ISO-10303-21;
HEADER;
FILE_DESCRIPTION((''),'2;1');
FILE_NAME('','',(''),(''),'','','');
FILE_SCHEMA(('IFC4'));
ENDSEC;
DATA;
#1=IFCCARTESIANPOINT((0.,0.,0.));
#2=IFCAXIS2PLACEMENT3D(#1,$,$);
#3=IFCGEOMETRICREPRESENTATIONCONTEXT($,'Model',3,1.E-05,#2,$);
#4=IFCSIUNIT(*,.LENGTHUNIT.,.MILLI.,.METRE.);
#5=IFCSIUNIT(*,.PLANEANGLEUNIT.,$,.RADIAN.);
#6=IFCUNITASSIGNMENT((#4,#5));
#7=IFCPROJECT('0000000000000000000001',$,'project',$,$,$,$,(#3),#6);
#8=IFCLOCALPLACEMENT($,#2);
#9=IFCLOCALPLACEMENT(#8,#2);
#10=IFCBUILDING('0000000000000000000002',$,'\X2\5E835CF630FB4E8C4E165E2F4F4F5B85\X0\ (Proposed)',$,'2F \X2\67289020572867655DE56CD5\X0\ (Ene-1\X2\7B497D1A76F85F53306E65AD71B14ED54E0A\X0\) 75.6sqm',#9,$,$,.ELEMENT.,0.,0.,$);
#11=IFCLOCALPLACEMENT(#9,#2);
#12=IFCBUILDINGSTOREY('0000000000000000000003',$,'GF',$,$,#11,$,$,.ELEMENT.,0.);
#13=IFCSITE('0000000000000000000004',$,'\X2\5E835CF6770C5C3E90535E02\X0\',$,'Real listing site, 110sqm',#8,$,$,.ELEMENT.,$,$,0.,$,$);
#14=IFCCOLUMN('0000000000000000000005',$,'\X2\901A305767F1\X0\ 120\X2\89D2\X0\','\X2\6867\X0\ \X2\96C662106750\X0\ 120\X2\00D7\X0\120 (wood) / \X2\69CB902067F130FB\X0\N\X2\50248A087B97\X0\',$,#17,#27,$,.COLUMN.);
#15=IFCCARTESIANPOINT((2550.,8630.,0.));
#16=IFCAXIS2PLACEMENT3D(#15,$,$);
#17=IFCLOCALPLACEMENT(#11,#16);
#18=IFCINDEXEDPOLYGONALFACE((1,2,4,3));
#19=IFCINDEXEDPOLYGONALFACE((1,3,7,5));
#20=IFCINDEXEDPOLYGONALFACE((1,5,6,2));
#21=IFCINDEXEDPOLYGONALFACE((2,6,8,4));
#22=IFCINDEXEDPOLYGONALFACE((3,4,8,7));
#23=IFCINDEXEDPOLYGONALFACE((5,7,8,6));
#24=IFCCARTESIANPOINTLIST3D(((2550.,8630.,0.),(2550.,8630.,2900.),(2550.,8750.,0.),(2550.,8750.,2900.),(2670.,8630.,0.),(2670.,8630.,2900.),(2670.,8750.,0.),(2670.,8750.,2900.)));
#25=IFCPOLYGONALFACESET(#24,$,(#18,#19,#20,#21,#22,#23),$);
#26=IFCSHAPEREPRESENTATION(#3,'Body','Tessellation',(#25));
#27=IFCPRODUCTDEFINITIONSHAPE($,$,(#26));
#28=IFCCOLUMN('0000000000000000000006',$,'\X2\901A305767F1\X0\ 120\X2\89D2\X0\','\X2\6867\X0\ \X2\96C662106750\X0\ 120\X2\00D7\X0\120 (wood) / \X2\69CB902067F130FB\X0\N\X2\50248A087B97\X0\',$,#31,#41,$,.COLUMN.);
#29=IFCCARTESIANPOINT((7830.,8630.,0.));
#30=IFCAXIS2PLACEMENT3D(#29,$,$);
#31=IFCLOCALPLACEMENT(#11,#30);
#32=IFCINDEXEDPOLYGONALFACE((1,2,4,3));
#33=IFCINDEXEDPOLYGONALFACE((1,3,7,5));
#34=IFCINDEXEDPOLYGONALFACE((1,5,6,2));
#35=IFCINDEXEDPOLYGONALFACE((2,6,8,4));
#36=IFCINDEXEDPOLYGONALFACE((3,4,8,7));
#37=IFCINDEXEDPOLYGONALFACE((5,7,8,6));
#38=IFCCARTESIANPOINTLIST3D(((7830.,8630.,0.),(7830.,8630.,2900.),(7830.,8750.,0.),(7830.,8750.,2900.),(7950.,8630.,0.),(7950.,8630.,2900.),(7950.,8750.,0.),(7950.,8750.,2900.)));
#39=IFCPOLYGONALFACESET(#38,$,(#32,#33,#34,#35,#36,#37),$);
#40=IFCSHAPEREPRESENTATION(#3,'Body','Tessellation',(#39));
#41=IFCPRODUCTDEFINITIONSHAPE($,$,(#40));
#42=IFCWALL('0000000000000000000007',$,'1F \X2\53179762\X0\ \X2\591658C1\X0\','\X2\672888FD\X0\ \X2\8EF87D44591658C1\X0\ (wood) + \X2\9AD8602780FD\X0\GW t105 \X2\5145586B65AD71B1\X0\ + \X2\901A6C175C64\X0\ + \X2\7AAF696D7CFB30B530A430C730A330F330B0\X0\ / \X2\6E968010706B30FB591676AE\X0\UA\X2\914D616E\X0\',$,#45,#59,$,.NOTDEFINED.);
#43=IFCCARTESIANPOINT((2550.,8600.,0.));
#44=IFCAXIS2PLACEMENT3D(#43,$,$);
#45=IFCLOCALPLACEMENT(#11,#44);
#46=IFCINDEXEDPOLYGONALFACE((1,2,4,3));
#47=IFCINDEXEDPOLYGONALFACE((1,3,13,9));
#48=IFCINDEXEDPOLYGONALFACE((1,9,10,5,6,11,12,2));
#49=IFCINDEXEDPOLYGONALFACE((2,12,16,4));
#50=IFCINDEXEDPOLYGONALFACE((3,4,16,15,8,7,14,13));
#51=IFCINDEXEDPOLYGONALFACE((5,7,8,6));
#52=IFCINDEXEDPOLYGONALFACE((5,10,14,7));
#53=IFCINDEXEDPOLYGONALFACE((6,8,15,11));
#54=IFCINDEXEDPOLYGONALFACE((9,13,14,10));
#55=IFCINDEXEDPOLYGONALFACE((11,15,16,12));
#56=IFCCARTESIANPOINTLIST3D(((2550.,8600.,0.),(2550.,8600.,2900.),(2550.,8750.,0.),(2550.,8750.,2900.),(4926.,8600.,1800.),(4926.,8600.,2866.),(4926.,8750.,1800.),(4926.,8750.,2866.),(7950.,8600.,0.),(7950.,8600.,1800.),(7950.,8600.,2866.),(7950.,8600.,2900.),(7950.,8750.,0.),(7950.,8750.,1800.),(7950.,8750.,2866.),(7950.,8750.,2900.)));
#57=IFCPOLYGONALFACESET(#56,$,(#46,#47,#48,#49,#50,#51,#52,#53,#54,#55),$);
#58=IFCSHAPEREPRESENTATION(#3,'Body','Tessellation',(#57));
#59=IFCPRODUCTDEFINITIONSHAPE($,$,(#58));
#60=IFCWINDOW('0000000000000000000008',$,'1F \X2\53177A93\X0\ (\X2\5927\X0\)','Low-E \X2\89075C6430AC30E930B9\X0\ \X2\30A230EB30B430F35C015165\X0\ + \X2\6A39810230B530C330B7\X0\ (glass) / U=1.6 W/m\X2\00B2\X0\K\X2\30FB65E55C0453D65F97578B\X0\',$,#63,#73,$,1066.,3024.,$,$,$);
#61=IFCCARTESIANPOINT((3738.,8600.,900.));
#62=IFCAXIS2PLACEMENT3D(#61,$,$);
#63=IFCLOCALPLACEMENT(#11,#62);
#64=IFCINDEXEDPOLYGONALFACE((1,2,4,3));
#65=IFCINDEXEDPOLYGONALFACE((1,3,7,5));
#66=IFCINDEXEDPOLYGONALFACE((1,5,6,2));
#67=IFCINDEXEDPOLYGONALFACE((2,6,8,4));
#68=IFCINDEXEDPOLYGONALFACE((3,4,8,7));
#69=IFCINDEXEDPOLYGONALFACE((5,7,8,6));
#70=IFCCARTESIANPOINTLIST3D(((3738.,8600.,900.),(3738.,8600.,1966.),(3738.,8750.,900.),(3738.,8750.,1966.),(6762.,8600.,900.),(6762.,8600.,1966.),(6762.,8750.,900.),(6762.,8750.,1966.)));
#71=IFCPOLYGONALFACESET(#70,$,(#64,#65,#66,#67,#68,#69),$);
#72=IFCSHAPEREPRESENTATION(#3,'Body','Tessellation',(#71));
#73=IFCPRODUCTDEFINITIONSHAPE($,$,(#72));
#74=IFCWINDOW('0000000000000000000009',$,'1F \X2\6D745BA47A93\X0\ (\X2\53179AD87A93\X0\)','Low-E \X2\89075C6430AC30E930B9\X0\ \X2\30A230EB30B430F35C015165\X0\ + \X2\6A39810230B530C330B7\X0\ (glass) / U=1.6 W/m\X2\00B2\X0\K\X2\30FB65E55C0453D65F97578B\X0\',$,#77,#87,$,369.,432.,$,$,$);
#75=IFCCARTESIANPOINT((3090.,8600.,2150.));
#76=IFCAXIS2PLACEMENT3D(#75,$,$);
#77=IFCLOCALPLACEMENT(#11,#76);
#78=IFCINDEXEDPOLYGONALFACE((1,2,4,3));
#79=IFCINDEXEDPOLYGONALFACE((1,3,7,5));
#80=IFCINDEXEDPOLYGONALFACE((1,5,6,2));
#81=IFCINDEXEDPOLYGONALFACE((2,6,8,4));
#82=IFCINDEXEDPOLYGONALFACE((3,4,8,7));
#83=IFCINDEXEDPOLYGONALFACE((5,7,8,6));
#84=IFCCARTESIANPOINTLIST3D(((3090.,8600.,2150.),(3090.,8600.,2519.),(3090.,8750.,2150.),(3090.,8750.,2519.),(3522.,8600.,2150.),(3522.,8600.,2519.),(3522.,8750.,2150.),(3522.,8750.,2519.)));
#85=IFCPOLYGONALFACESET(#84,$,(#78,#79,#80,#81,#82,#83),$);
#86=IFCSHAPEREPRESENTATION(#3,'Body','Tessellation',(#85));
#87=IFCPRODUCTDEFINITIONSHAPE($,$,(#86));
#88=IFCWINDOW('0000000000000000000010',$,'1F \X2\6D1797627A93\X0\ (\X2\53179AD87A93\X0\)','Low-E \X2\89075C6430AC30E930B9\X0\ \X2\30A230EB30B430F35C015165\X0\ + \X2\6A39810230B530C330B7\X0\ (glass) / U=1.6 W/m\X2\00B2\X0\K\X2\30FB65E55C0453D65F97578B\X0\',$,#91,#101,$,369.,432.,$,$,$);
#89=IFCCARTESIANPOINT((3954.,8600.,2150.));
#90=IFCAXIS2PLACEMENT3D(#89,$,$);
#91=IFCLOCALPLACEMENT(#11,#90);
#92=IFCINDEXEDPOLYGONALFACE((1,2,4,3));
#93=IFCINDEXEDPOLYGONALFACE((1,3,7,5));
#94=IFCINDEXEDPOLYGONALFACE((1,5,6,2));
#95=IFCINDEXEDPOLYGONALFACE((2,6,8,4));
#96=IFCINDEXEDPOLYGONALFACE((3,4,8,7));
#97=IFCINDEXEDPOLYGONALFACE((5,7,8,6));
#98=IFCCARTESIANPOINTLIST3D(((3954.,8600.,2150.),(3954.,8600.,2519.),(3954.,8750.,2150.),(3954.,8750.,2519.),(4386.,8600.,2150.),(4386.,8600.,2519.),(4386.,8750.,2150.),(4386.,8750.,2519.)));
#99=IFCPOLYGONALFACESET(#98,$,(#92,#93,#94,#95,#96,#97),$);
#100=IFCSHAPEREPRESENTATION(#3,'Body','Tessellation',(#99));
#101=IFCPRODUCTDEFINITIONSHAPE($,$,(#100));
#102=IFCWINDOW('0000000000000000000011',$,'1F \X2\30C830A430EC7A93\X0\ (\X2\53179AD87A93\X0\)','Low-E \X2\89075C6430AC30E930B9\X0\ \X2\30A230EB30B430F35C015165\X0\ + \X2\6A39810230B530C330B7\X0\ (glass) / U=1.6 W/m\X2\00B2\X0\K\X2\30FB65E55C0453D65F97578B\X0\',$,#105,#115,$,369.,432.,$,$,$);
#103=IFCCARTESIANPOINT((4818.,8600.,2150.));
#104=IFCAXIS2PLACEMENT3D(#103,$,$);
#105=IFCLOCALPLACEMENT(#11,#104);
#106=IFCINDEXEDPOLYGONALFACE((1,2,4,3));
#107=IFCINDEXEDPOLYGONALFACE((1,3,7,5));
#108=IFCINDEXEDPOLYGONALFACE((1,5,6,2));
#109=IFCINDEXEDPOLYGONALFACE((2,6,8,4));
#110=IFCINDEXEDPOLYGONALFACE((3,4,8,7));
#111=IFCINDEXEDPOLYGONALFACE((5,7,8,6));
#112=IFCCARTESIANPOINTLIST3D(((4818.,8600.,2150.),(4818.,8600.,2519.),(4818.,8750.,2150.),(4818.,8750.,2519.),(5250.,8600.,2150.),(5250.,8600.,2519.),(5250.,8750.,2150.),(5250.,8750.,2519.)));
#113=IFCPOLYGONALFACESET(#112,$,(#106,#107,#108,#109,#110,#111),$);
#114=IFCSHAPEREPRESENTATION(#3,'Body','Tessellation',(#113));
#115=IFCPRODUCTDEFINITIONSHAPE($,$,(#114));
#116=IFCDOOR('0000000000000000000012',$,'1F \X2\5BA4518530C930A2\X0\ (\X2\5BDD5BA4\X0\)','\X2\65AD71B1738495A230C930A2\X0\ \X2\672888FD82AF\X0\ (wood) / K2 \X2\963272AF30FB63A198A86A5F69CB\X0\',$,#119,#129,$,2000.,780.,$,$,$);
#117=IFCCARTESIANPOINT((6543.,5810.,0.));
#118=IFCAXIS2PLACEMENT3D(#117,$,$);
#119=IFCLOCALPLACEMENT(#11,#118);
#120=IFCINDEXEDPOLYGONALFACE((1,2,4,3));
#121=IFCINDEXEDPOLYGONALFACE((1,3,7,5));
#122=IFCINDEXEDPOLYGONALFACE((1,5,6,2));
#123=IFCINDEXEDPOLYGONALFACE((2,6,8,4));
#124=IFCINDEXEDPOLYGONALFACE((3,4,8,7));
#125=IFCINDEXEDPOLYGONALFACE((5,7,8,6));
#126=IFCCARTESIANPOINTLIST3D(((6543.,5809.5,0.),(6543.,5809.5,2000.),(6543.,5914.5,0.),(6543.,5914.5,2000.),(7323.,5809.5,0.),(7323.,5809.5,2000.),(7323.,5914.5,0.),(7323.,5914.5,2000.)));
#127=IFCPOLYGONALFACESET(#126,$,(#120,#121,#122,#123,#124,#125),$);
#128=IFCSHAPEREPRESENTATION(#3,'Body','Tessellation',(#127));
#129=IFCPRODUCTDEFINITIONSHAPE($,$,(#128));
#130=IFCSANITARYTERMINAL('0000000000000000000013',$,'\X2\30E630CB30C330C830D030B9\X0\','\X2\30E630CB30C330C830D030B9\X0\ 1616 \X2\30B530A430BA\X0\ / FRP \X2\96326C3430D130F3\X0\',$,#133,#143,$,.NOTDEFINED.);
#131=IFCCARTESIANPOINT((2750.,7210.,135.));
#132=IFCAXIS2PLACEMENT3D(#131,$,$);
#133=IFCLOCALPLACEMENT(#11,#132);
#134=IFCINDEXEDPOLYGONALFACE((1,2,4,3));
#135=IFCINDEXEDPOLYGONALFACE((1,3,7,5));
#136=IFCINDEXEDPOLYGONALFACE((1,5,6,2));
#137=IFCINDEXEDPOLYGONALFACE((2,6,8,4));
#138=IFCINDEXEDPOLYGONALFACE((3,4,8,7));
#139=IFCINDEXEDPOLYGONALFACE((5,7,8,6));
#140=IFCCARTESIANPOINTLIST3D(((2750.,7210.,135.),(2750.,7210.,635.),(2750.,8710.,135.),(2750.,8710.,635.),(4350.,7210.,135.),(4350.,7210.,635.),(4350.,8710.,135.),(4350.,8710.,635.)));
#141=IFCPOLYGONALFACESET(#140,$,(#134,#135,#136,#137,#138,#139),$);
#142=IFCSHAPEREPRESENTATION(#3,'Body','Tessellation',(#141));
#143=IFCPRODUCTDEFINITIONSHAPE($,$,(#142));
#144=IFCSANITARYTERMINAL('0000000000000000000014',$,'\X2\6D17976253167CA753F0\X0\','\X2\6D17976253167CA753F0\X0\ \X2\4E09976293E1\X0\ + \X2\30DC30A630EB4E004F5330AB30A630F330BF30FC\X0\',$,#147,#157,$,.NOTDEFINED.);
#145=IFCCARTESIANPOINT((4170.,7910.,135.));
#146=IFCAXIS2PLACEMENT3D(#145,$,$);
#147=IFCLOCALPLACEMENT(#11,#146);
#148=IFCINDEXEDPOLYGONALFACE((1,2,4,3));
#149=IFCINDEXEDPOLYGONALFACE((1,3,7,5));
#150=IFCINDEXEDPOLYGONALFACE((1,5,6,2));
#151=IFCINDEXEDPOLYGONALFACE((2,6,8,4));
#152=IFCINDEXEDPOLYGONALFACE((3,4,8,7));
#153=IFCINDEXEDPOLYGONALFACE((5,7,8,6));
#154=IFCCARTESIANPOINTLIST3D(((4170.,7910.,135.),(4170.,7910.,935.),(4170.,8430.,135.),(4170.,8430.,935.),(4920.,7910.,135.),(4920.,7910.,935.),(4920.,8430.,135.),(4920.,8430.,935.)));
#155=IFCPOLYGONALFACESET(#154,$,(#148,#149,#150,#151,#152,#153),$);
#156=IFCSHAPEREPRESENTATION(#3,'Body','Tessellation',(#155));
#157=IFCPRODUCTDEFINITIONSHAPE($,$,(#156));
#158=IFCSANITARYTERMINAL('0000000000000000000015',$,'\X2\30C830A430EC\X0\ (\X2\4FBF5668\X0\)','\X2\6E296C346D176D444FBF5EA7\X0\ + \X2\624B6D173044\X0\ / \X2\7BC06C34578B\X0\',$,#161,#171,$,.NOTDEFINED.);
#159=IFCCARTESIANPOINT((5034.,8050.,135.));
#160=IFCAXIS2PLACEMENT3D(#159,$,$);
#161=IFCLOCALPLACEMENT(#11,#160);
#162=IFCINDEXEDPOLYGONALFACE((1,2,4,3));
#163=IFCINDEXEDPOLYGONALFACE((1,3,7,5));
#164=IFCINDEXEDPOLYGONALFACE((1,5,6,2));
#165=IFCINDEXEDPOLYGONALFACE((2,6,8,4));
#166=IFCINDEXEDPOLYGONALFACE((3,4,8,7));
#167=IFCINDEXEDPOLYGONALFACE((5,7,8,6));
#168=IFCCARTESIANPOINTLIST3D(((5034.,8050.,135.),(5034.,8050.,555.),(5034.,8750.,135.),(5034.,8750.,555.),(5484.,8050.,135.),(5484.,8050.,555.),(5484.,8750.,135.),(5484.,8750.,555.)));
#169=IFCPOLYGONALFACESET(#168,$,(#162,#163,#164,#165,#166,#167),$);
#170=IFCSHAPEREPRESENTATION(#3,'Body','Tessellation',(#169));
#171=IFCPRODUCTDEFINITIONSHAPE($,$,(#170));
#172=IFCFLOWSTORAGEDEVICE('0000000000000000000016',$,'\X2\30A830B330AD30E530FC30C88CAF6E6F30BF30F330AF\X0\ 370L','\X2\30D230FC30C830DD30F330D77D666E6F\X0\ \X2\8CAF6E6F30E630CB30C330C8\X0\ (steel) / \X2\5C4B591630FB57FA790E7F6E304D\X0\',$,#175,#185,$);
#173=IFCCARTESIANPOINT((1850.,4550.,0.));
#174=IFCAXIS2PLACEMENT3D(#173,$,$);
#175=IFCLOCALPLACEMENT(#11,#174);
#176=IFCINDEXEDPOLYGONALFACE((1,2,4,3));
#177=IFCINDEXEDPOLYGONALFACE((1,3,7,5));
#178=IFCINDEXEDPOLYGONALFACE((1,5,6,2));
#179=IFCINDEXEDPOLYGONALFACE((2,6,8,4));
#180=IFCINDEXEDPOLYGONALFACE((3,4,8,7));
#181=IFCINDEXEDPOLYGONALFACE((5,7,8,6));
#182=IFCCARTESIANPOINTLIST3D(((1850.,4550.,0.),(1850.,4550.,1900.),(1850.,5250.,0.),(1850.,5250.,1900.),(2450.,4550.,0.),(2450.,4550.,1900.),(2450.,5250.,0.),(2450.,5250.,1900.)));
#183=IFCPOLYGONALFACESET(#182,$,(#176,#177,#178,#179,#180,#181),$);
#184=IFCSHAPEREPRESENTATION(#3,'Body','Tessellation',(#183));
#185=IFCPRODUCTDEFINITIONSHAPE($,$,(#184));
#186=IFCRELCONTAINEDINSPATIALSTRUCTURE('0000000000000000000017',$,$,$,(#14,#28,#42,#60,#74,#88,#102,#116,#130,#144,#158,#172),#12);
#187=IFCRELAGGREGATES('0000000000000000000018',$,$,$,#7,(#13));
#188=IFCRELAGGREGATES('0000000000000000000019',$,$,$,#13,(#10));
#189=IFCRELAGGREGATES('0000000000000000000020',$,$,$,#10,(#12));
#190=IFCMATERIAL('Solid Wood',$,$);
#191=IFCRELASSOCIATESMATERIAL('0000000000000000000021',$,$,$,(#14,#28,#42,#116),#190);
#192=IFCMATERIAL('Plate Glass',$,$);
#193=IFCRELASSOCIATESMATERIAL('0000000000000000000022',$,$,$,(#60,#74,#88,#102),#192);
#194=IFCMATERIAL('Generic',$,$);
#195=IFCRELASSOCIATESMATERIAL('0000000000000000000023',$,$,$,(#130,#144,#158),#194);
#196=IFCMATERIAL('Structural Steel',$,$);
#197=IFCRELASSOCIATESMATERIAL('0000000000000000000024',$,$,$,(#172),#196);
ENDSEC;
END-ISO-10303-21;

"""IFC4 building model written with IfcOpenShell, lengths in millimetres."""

from ifc_helpers import new_model, si_unit, frame, frame_2d, origin, place, context, project, spatial, rectangle, extrude, material, element, fill, save


model = new_model("IFC4")

# Units and contexts
model_context = context("Model", 3, precision=1e-05, world=origin())
ifc_project = project(units=[si_unit("LENGTHUNIT", "METRE", prefix="MILLI"), si_unit("PLANEANGLEUNIT", "RADIAN")], contexts=[model_context])

# Site, building, storey
site_placement = place(None, origin())
site = spatial("IfcSite", under=ifc_project, at=site_placement, Name="広島県尾道市", ObjectType="Real listing site, 110sqm", CompositionType="ELEMENT", RefElevation=0.0)
building_placement = place(site_placement, origin())
building = spatial("IfcBuilding", under=site, at=building_placement, Name="広島・二世帯住宅 (Proposed)", ObjectType="2F 木造在来工法 (Ene-1等級相当の断熱仕上) 75.6sqm", CompositionType="ELEMENT", ElevationOfRefHeight=0.0, ElevationOfTerrain=0.0)
storey_placement = place(building_placement, origin())
storey = spatial("IfcBuildingStorey", under=building, at=storey_placement, Name="GF", CompositionType="ELEMENT", Elevation=0.0)

# Columns
ifc_material_1 = material(Name="Solid Wood")
column_1_placement = place(storey_placement, frame((2550.0, 8630.0, 0.0)))
element("IfcColumn", 1, at=column_1_placement, inside=storey, material=ifc_material_1, Name="通し柱 120角", Description="桧 集成材 120×120 (wood) / 構造柱・N値計算", PredefinedType="COLUMN", context=model_context, shape_type="SweptSolid", body=[
    extrude(rectangle(XDim=120.0, YDim=120.0, at=frame_2d((60.0, 60.0))), frame((2550.0, 8630.0, 0.0)), (0.0, 0.0, 1.0), 2900.0),
])
column_2_placement = place(storey_placement, frame((7830.0, 8630.0, 0.0)))
element("IfcColumn", 2, at=column_2_placement, inside=storey, material=ifc_material_1, Name="通し柱 120角", Description="桧 集成材 120×120 (wood) / 構造柱・N値計算", PredefinedType="COLUMN", context=model_context, shape_type="SweptSolid", body=[
    extrude(rectangle(XDim=120.0, YDim=120.0, at=frame_2d((60.0, 60.0))), frame((7830.0, 8630.0, 0.0)), (0.0, 0.0, 1.0), 2900.0),
])

# Wall, openings, windows
wall_1_placement = place(storey_placement, frame((2550.0, 8600.0, 0.0)))
wall_1 = element("IfcWall", 3, at=wall_1_placement, inside=storey, material=ifc_material_1, Name="1F 北面 外壁", Description="木製 軸組外壁 (wood) + 高性能GW t105 充填断熱 + 通気層 + 窯業系サイディング / 準耐火・外皮UA配慮", PredefinedType="NOTDEFINED", context=model_context, shape_type="SweptSolid", body=[
    extrude(rectangle(XDim=5400.0, YDim=150.0, at=frame_2d((2700.0, 75.0))), frame((2550.0, 8600.0, 0.0)), (0.0, 0.0, 1.0), 2900.0),
])
opening_1_placement = place(storey_placement, frame((3738.0, 8600.0, 900.0)))
opening_1 = element("IfcOpeningElement", 4, at=opening_1_placement, cuts=wall_1, PredefinedType="NOTDEFINED", context=model_context, shape_type="SweptSolid", body=[
    extrude(rectangle(XDim=3024.0, YDim=150.0, at=frame_2d((1512.0, 75.0))), frame((3738.0, 8600.0, 900.0)), (0.0, 0.0, 1.0), 1066.0),
])
opening_2_placement = place(storey_placement, frame((3090.0, 8600.0, 2150.0)))
opening_2 = element("IfcOpeningElement", 5, at=opening_2_placement, cuts=wall_1, PredefinedType="NOTDEFINED", context=model_context, shape_type="SweptSolid", body=[
    extrude(rectangle(XDim=432.0, YDim=150.0, at=frame_2d((216.0, 75.0))), frame((3090.0, 8600.0, 2150.0)), (0.0, 0.0, 1.0), 369.0),
])
opening_3_placement = place(storey_placement, frame((3954.0, 8600.0, 2150.0)))
opening_3 = element("IfcOpeningElement", 6, at=opening_3_placement, cuts=wall_1, PredefinedType="NOTDEFINED", context=model_context, shape_type="SweptSolid", body=[
    extrude(rectangle(XDim=432.0, YDim=150.0, at=frame_2d((216.0, 75.0))), frame((3954.0, 8600.0, 2150.0)), (0.0, 0.0, 1.0), 369.0),
])
opening_4_placement = place(storey_placement, frame((4818.0, 8600.0, 2150.0)))
opening_4 = element("IfcOpeningElement", 7, at=opening_4_placement, cuts=wall_1, PredefinedType="NOTDEFINED", context=model_context, shape_type="SweptSolid", body=[
    extrude(rectangle(XDim=432.0, YDim=150.0, at=frame_2d((216.0, 75.0))), frame((4818.0, 8600.0, 2150.0)), (0.0, 0.0, 1.0), 369.0),
])
ifc_material_2 = material(Name="Plate Glass")
window_1_placement = place(storey_placement, frame((3738.0, 8600.0, 900.0)))
window_1 = element("IfcWindow", 8, at=window_1_placement, inside=storey, material=ifc_material_2, Name="1F 北窓 (大)", Description="Low-E 複層ガラス アルゴン封入 + 樹脂サッシ (glass) / U=1.6 W/m²K・日射取得型", OverallHeight=1066.0, OverallWidth=3024.0, context=model_context, shape_type="SweptSolid", body=[
    extrude(rectangle(XDim=3024.0, YDim=150.0, at=frame_2d((1512.0, 75.0))), frame((3738.0, 8600.0, 900.0)), (0.0, 0.0, 1.0), 1066.0),
])
fill(opening_1, window_1)
window_2_placement = place(storey_placement, frame((3090.0, 8600.0, 2150.0)))
window_2 = element("IfcWindow", 9, at=window_2_placement, inside=storey, material=ifc_material_2, Name="1F 浴室窓 (北高窓)", Description="Low-E 複層ガラス アルゴン封入 + 樹脂サッシ (glass) / U=1.6 W/m²K・日射取得型", OverallHeight=369.0, OverallWidth=432.0, context=model_context, shape_type="SweptSolid", body=[
    extrude(rectangle(XDim=432.0, YDim=150.0, at=frame_2d((216.0, 75.0))), frame((3090.0, 8600.0, 2150.0)), (0.0, 0.0, 1.0), 369.0),
])
fill(opening_2, window_2)
window_3_placement = place(storey_placement, frame((3954.0, 8600.0, 2150.0)))
window_3 = element("IfcWindow", 10, at=window_3_placement, inside=storey, material=ifc_material_2, Name="1F 洗面窓 (北高窓)", Description="Low-E 複層ガラス アルゴン封入 + 樹脂サッシ (glass) / U=1.6 W/m²K・日射取得型", OverallHeight=369.0, OverallWidth=432.0, context=model_context, shape_type="SweptSolid", body=[
    extrude(rectangle(XDim=432.0, YDim=150.0, at=frame_2d((216.0, 75.0))), frame((3954.0, 8600.0, 2150.0)), (0.0, 0.0, 1.0), 369.0),
])
fill(opening_3, window_3)
window_4_placement = place(storey_placement, frame((4818.0, 8600.0, 2150.0)))
window_4 = element("IfcWindow", 11, at=window_4_placement, inside=storey, material=ifc_material_2, Name="1F トイレ窓 (北高窓)", Description="Low-E 複層ガラス アルゴン封入 + 樹脂サッシ (glass) / U=1.6 W/m²K・日射取得型", OverallHeight=369.0, OverallWidth=432.0, context=model_context, shape_type="SweptSolid", body=[
    extrude(rectangle(XDim=432.0, YDim=150.0, at=frame_2d((216.0, 75.0))), frame((4818.0, 8600.0, 2150.0)), (0.0, 0.0, 1.0), 369.0),
])
fill(opening_4, window_4)

# Door
door_1_placement = place(storey_placement, frame((6543.0, 5810.0, 0.0)))
element("IfcDoor", 12, at=door_1_placement, inside=storey, material=ifc_material_1, Name="1F 室内ドア (寝室)", Description="断熱玄関ドア 木製芯 (wood) / K2 防犯・採風機構", OverallHeight=2000.0, OverallWidth=780.0, context=model_context, shape_type="SweptSolid", body=[
    extrude(rectangle(XDim=780.0, YDim=105.0, at=frame_2d((390.0, 52.0))), frame((6543.0, 5810.0, 0.0)), (0.0, 0.0, 1.0), 2000.0),
])

# Sanitary terminals
ifc_material_3 = material(Name="Generic")
sanitary_terminal_1_placement = place(storey_placement, frame((2750.0, 7210.0, 135.0)))
element("IfcSanitaryTerminal", 13, at=sanitary_terminal_1_placement, inside=storey, material=ifc_material_3, Name="ユニットバス", Description="ユニットバス 1616 サイズ / FRP 防水パン", PredefinedType="NOTDEFINED", context=model_context, shape_type="SweptSolid", body=[
    extrude(rectangle(XDim=1600.0, YDim=1500.0, at=frame_2d((800.0, 750.0))), frame((2750.0, 7210.0, 135.0)), (0.0, 0.0, 1.0), 500.0),
])
sanitary_terminal_2_placement = place(storey_placement, frame((4170.0, 7910.0, 135.0)))
element("IfcSanitaryTerminal", 14, at=sanitary_terminal_2_placement, inside=storey, material=ifc_material_3, Name="洗面化粧台", Description="洗面化粧台 三面鏡 + ボウル一体カウンター", PredefinedType="NOTDEFINED", context=model_context, shape_type="SweptSolid", body=[
    extrude(rectangle(XDim=750.0, YDim=520.0, at=frame_2d((375.0, 260.0))), frame((4170.0, 7910.0, 135.0)), (0.0, 0.0, 1.0), 800.0),
])
sanitary_terminal_3_placement = place(storey_placement, frame((5034.0, 8050.0, 135.0)))
element("IfcSanitaryTerminal", 15, at=sanitary_terminal_3_placement, inside=storey, material=ifc_material_3, Name="トイレ (便器)", Description="温水洗浄便座 + 手洗い / 節水型", PredefinedType="NOTDEFINED", context=model_context, shape_type="SweptSolid", body=[
    extrude(rectangle(XDim=450.0, YDim=700.0, at=frame_2d((225.0, 350.0))), frame((5034.0, 8050.0, 135.0)), (0.0, 0.0, 1.0), 420.0),
])

# Flow storage device
ifc_material_4 = material(Name="Structural Steel")
flow_storage_device_placement = place(storey_placement, frame((1850.0, 4550.0, 0.0)))
element("IfcFlowStorageDevice", 16, at=flow_storage_device_placement, inside=storey, material=ifc_material_4, Name="エコキュート貯湯タンク 370L", Description="ヒートポンプ給湯 貯湯ユニット (steel) / 屋外・基礎置き", context=model_context, shape_type="SweptSolid", body=[
    extrude(rectangle(XDim=600.0, YDim=700.0, at=frame_2d((300.0, 350.0))), frame((1850.0, 4550.0, 0.0)), (0.0, 0.0, 1.0), 1900.0),
])

save(model, "model.ifc")
